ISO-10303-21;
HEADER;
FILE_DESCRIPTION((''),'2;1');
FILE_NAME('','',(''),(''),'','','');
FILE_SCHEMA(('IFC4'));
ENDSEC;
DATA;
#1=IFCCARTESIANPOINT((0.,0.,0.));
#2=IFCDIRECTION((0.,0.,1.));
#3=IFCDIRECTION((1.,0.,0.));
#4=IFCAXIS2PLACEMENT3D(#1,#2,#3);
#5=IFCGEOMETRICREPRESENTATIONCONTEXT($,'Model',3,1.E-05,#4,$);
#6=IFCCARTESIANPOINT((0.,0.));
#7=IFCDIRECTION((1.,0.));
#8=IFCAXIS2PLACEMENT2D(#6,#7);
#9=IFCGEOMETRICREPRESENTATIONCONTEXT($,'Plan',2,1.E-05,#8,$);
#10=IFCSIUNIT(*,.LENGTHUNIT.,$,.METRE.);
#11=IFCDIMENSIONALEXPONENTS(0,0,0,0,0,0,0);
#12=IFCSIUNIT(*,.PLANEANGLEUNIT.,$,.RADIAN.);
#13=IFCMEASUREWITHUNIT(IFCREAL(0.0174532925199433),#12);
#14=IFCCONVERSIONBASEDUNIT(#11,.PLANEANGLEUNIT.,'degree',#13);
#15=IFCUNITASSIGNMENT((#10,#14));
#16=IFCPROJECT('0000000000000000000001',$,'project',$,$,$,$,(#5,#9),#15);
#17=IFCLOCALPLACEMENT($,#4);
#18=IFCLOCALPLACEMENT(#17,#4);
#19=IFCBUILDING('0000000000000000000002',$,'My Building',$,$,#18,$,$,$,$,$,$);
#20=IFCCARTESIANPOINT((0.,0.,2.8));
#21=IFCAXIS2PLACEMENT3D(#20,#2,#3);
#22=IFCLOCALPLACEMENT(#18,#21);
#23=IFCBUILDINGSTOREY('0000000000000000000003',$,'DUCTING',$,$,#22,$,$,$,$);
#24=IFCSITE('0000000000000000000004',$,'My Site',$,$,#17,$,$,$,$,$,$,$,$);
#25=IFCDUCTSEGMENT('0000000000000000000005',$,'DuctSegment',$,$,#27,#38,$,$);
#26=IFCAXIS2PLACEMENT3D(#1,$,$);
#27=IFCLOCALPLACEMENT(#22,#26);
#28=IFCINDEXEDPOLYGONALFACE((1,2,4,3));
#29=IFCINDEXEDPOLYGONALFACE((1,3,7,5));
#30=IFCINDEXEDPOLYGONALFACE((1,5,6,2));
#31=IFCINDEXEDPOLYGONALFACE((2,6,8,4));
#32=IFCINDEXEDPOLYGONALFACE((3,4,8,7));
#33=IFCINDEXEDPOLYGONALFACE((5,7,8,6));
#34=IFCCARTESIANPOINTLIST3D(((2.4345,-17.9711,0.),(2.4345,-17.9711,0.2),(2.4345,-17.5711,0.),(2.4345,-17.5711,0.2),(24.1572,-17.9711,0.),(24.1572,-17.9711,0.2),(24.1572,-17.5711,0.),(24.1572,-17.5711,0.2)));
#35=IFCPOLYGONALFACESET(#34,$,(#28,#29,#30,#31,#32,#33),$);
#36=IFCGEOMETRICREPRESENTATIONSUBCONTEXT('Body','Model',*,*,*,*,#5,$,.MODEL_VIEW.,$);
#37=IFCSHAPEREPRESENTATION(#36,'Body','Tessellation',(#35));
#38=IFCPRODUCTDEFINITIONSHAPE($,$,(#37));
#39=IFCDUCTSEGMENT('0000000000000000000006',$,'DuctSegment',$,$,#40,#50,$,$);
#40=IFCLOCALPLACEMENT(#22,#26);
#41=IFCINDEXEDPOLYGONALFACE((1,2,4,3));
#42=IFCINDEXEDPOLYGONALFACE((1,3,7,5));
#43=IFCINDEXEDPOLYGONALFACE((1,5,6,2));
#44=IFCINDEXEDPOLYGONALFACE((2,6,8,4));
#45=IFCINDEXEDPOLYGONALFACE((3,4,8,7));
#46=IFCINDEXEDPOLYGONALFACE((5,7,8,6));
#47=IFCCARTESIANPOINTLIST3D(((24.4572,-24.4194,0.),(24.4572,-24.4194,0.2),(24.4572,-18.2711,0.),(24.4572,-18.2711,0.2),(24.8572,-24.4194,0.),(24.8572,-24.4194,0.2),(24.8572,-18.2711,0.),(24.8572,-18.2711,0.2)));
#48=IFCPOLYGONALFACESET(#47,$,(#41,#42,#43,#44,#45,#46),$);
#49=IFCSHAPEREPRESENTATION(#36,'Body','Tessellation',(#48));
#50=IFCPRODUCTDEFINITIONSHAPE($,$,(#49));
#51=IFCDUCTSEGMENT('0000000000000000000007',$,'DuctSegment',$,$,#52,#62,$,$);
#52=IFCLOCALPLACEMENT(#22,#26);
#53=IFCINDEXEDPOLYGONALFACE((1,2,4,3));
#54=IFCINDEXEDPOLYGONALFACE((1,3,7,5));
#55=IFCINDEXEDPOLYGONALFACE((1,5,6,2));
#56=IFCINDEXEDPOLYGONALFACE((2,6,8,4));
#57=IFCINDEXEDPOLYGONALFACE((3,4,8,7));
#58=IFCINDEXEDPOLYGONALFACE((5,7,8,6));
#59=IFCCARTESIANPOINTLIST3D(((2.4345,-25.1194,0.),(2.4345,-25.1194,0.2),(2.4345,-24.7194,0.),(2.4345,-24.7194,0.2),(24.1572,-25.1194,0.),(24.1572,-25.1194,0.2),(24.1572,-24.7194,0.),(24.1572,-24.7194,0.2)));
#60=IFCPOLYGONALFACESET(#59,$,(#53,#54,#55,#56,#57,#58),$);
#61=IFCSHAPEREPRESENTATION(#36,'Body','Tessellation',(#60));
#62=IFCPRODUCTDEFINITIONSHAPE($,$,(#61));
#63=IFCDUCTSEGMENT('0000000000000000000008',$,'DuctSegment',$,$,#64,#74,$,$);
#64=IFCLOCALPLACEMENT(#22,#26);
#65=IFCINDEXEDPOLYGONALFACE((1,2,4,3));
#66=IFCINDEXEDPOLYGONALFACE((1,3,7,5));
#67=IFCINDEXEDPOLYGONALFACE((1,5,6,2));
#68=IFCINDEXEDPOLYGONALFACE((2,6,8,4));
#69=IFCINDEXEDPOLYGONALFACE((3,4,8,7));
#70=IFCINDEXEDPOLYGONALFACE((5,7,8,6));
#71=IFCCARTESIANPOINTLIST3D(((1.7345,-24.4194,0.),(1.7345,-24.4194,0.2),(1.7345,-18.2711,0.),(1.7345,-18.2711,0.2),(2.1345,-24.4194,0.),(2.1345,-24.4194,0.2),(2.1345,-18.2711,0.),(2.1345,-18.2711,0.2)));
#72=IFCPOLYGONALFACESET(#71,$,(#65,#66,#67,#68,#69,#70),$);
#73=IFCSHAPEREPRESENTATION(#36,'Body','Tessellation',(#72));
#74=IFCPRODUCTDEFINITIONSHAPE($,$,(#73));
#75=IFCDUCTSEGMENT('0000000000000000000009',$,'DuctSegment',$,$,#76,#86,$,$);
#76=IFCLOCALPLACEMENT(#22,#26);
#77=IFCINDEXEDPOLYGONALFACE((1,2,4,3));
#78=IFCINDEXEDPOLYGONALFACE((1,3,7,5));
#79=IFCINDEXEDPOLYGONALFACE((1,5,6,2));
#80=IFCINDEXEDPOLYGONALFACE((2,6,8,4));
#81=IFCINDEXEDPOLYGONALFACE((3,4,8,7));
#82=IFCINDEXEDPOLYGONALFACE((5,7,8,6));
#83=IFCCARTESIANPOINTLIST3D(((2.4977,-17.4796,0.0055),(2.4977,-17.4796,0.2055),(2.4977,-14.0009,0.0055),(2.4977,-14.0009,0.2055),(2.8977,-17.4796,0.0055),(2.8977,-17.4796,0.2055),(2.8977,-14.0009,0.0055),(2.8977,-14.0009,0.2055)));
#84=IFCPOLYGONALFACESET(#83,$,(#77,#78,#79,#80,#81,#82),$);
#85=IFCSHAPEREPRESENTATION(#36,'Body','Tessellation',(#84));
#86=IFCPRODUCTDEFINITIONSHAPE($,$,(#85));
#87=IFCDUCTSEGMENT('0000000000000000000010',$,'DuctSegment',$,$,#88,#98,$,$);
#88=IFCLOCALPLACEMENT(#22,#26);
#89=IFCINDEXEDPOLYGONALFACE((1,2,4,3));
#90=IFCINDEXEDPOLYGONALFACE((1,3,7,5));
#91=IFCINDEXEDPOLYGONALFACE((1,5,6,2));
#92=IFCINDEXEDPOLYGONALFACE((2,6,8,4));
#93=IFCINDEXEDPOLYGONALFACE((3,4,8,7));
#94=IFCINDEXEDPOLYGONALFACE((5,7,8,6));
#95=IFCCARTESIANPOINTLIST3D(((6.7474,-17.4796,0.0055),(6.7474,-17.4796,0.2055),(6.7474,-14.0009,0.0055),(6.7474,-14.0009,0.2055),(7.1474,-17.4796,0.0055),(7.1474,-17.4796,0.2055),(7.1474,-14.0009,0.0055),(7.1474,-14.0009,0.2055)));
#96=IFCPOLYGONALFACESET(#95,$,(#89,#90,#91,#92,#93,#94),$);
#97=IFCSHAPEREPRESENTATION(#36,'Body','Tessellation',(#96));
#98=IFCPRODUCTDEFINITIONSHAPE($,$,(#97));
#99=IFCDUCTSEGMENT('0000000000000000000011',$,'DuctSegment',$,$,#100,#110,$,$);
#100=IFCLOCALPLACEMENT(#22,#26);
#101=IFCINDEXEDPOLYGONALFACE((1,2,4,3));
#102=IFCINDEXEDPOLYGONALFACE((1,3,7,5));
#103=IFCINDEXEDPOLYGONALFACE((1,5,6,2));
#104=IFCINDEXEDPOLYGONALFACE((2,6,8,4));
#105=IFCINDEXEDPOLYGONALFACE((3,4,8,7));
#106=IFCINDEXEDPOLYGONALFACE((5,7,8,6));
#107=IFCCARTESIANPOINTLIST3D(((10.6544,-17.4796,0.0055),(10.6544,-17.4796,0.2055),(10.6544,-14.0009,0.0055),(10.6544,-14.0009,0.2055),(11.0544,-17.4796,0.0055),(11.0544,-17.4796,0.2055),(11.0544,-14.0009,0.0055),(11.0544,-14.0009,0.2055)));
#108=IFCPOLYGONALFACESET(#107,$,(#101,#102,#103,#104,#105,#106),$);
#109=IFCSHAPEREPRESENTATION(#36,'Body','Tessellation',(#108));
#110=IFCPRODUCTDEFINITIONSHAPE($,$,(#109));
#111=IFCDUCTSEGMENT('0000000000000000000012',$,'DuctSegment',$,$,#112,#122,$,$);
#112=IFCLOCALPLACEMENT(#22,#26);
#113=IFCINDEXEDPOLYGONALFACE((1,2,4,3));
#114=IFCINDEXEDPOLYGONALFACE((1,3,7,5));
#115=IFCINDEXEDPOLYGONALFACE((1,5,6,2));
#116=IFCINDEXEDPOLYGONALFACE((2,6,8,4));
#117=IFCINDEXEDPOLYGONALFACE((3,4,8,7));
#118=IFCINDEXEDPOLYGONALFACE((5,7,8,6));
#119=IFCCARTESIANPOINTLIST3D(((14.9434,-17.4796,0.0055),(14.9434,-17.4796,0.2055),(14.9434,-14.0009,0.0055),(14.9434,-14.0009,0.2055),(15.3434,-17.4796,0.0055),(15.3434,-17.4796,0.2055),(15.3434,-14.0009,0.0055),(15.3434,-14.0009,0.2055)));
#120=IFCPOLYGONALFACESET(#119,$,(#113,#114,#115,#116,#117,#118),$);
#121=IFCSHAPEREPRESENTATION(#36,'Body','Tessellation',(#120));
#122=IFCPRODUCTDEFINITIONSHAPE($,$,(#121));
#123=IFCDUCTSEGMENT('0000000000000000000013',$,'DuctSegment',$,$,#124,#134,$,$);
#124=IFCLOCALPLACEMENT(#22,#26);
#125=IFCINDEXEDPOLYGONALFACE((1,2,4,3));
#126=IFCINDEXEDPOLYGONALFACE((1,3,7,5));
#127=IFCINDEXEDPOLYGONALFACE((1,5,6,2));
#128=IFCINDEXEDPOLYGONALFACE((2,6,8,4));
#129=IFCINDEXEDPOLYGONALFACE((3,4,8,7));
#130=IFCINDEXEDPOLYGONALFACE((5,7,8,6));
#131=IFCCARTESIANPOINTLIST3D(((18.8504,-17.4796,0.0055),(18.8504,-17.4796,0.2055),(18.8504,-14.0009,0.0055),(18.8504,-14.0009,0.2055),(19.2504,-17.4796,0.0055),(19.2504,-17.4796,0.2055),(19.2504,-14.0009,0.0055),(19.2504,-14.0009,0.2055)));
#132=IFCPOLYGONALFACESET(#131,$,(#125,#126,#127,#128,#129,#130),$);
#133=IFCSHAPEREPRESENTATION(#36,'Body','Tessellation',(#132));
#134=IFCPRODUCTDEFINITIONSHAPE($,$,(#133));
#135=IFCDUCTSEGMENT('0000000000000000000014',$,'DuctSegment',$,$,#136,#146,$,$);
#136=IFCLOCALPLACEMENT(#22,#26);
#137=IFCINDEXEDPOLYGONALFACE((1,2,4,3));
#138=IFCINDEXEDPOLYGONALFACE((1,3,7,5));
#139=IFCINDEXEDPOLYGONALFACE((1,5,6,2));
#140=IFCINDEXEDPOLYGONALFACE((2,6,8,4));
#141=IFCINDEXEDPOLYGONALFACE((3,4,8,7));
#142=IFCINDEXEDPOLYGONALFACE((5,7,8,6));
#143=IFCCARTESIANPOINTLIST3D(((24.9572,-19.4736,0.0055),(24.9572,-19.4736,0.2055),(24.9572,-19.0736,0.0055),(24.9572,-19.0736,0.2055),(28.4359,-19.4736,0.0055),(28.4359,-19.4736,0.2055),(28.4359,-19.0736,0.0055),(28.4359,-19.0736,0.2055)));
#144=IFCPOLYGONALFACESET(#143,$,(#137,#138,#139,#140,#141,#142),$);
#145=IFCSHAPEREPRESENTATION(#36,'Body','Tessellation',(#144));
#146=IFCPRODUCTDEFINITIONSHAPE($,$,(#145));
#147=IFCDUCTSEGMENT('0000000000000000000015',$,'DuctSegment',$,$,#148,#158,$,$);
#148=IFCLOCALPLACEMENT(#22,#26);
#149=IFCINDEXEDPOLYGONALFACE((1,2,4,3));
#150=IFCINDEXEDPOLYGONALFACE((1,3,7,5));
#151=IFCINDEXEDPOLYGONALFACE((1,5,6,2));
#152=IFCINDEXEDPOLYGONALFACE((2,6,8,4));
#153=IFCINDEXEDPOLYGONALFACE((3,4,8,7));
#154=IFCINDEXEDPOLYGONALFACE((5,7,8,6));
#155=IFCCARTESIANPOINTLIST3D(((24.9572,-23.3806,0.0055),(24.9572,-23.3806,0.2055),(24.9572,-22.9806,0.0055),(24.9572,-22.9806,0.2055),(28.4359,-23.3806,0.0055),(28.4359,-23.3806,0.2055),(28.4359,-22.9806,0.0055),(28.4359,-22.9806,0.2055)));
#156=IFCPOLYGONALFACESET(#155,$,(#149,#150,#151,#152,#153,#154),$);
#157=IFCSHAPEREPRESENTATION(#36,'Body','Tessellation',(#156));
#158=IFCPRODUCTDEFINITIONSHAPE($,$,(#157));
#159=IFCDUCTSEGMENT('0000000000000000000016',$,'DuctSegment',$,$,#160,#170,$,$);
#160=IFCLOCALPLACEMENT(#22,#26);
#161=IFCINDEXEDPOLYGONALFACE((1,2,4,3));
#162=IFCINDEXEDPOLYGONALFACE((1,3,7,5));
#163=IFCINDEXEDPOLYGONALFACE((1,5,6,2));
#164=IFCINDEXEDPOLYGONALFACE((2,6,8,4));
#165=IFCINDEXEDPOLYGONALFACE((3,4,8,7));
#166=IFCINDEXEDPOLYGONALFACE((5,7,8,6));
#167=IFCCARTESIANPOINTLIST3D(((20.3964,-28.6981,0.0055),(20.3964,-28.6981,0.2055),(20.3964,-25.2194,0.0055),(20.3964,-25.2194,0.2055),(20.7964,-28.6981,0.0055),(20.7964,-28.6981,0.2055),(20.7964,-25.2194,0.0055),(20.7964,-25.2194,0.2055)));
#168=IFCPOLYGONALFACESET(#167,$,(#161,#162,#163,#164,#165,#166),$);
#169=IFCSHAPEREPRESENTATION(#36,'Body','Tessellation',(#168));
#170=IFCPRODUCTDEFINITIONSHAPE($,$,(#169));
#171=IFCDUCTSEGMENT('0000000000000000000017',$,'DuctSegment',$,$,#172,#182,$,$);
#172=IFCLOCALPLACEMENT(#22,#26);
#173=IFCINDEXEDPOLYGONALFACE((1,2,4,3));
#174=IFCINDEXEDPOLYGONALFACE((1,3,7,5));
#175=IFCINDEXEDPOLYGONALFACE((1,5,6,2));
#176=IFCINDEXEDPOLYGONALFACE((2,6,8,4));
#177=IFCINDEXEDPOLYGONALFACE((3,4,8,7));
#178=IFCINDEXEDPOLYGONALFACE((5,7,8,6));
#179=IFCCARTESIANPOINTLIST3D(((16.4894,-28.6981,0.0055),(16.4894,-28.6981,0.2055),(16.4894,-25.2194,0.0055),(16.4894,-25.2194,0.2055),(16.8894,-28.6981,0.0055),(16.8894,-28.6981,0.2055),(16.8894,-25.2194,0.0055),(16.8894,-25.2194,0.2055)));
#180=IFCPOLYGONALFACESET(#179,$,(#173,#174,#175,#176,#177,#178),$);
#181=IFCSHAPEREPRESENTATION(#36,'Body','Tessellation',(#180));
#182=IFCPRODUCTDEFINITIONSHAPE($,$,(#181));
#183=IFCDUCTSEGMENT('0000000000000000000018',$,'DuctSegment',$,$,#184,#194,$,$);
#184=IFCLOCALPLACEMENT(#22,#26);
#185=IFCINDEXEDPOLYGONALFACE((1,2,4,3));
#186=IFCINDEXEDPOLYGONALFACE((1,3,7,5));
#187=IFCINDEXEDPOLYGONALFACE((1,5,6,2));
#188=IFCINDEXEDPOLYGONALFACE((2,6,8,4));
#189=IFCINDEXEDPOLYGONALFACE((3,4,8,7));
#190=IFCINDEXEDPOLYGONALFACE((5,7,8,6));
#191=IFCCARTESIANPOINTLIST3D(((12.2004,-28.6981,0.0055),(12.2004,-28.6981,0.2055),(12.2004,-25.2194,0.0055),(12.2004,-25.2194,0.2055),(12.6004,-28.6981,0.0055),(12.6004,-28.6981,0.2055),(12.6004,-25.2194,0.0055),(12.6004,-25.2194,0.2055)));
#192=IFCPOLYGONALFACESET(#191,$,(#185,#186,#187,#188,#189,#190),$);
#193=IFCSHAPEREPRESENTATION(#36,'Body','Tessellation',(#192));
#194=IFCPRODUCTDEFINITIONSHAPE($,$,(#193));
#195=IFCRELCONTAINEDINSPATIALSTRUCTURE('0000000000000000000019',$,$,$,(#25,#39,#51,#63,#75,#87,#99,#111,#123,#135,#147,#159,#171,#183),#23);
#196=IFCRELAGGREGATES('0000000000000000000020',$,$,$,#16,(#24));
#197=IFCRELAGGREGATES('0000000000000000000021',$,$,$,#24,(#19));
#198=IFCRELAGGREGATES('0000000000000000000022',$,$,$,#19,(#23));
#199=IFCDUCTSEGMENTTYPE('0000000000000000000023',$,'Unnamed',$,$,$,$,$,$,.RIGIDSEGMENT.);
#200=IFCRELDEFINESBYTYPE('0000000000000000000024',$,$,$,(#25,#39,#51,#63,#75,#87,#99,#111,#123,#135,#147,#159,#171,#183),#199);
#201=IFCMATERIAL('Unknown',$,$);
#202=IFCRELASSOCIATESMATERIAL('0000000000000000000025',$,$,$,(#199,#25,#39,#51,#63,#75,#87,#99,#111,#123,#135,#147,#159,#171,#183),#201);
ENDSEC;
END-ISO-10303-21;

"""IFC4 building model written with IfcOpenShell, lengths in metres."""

from ifc_helpers import new_model, entity, si_unit, converted_unit, frame, origin_with_axes, origin_2d_with_axis, place, context, subcontext, project, spatial, rectangle, extrude, material, material_profile, profile_set, profile_usage, type_object, element, save


model = new_model("IFC4")

# Units and contexts
model_context = context("Model", 3, precision=1e-05, world=origin_with_axes())
plan_context = context("Plan", 2, precision=1e-05, world=origin_2d_with_axis())
body_context = subcontext(model_context, "Body", "Model", "MODEL_VIEW")
ifc_project = project(units=[si_unit("LENGTHUNIT", "METRE"), converted_unit("PLANEANGLEUNIT", "degree", entity("IfcReal", 0.0174532925199433), si_unit("PLANEANGLEUNIT", "RADIAN"), dimensions=[0, 0, 0, 0, 0, 0, 0])], contexts=[model_context, plan_context])

# Site, building, storey
site_placement = place(None, origin_with_axes())
site = spatial("IfcSite", under=ifc_project, at=site_placement, Name="My Site")
building_placement = place(site_placement, origin_with_axes())
building = spatial("IfcBuilding", under=site, at=building_placement, Name="My Building")
storey_placement = place(building_placement, frame((0.0, 0.0, 2.8), z_axis=(0.0, 0.0, 1.0), x_axis=(1.0, 0.0, 0.0)))
storey = spatial("IfcBuildingStorey", under=building, at=storey_placement, Name="DUCTING")

# Duct segments
ifc_material = material(Name="Unknown")
ifc_material_profile = material_profile(ifc_material, rectangle(XDim=0.4, YDim=0.2))
ifc_profile_set = profile_set([ifc_material_profile])
ifc_profile_usage_1 = profile_usage(ifc_profile_set, cardinal=5)
duct_segment_type = type_object("IfcDuctSegmentType", Name="Unnamed", PredefinedType="RIGIDSEGMENT", material=ifc_profile_set)
duct_segment_1_placement = place(storey_placement, frame((24.1572, -17.7711, 0.1), z_axis=(-1.0, 0.0, 0.0), x_axis=(0.0, -1.0, 0.0)))
element("IfcDuctSegment", 1, at=duct_segment_1_placement, inside=storey, type_object=duct_segment_type, material=ifc_profile_usage_1, Name="DuctSegment", context=body_context, shape_type="SweptSolid", body=[
    extrude(rectangle(XDim=0.4, YDim=0.2), origin_with_axes(), (0.0, 0.0, 1.0), 21.7227),
])
ifc_profile_usage_2 = profile_usage(ifc_profile_set, cardinal=5)
duct_segment_2_placement = place(storey_placement, frame((24.6572, -18.2711, 0.1), z_axis=(0.0, -1.0, 0.0), x_axis=(1.0, 0.0, 0.0)))
element("IfcDuctSegment", 2, at=duct_segment_2_placement, inside=storey, type_object=duct_segment_type, material=ifc_profile_usage_2, Name="DuctSegment", context=body_context, shape_type="SweptSolid", body=[
    extrude(rectangle(XDim=0.4, YDim=0.2), origin_with_axes(), (0.0, 0.0, 1.0), 6.1483),
])
ifc_profile_usage_3 = profile_usage(ifc_profile_set, cardinal=5)
duct_segment_3_placement = place(storey_placement, frame((24.1572, -24.9194, 0.1), z_axis=(-1.0, 0.0, 0.0), x_axis=(0.0, -1.0, 0.0)))
element("IfcDuctSegment", 3, at=duct_segment_3_placement, inside=storey, type_object=duct_segment_type, material=ifc_profile_usage_3, Name="DuctSegment", context=body_context, shape_type="SweptSolid", body=[
    extrude(rectangle(XDim=0.4, YDim=0.2), origin_with_axes(), (0.0, 0.0, 1.0), 21.7227),
])
ifc_profile_usage_4 = profile_usage(ifc_profile_set, cardinal=5)
duct_segment_4_placement = place(storey_placement, frame((1.9345, -18.2711, 0.1), z_axis=(0.0, -1.0, 0.0), x_axis=(1.0, 0.0, 0.0)))
element("IfcDuctSegment", 4, at=duct_segment_4_placement, inside=storey, type_object=duct_segment_type, material=ifc_profile_usage_4, Name="DuctSegment", context=body_context, shape_type="SweptSolid", body=[
    extrude(rectangle(XDim=0.4, YDim=0.2), origin_with_axes(), (0.0, 0.0, 1.0), 6.1483),
])
ifc_profile_usage_5 = profile_usage(ifc_profile_set, cardinal=5)
duct_segment_5_placement = place(storey_placement, frame((2.6977, -17.4796, 0.1055), z_axis=(0.0, 1.0, 0.0), x_axis=(-1.0, 0.0, 0.0)))
element("IfcDuctSegment", 5, at=duct_segment_5_placement, inside=storey, type_object=duct_segment_type, material=ifc_profile_usage_5, Name="DuctSegment", context=body_context, shape_type="SweptSolid", body=[
    extrude(rectangle(XDim=0.4, YDim=0.2), origin_with_axes(), (0.0, 0.0, 1.0), 3.4787),
])
ifc_profile_usage_6 = profile_usage(ifc_profile_set, cardinal=5)
duct_segment_6_placement = place(storey_placement, frame((6.9474, -17.4796, 0.1055), z_axis=(0.0, 1.0, 0.0), x_axis=(-1.0, 0.0, 0.0)))
element("IfcDuctSegment", 6, at=duct_segment_6_placement, inside=storey, type_object=duct_segment_type, material=ifc_profile_usage_6, Name="DuctSegment", context=body_context, shape_type="SweptSolid", body=[
    extrude(rectangle(XDim=0.4, YDim=0.2), origin_with_axes(), (0.0, 0.0, 1.0), 3.4787),
])
ifc_profile_usage_7 = profile_usage(ifc_profile_set, cardinal=5)
duct_segment_7_placement = place(storey_placement, frame((10.8544, -17.4796, 0.1055), z_axis=(0.0, 1.0, 0.0), x_axis=(-1.0, 0.0, 0.0)))
element("IfcDuctSegment", 7, at=duct_segment_7_placement, inside=storey, type_object=duct_segment_type, material=ifc_profile_usage_7, Name="DuctSegment", context=body_context, shape_type="SweptSolid", body=[
    extrude(rectangle(XDim=0.4, YDim=0.2), origin_with_axes(), (0.0, 0.0, 1.0), 3.4787),
])
ifc_profile_usage_8 = profile_usage(ifc_profile_set, cardinal=5)
duct_segment_8_placement = place(storey_placement, frame((15.1434, -17.4796, 0.1055), z_axis=(0.0, 1.0, 0.0), x_axis=(-1.0, 0.0, 0.0)))
element("IfcDuctSegment", 8, at=duct_segment_8_placement, inside=storey, type_object=duct_segment_type, material=ifc_profile_usage_8, Name="DuctSegment", context=body_context, shape_type="SweptSolid", body=[
    extrude(rectangle(XDim=0.4, YDim=0.2), origin_with_axes(), (0.0, 0.0, 1.0), 3.4787),
])
ifc_profile_usage_9 = profile_usage(ifc_profile_set, cardinal=5)
duct_segment_9_placement = place(storey_placement, frame((19.0504, -17.4796, 0.1055), z_axis=(0.0, 1.0, 0.0), x_axis=(-1.0, 0.0, 0.0)))
element("IfcDuctSegment", 9, at=duct_segment_9_placement, inside=storey, type_object=duct_segment_type, material=ifc_profile_usage_9, Name="DuctSegment", context=body_context, shape_type="SweptSolid", body=[
    extrude(rectangle(XDim=0.4, YDim=0.2), origin_with_axes(), (0.0, 0.0, 1.0), 3.4787),
])
ifc_profile_usage_10 = profile_usage(ifc_profile_set, cardinal=5)
duct_segment_10_placement = place(storey_placement, frame((24.9572, -19.2736, 0.1055), z_axis=(1.0, 0.0, 0.0), x_axis=(0.0, 1.0, 0.0)))
element("IfcDuctSegment", 10, at=duct_segment_10_placement, inside=storey, type_object=duct_segment_type, material=ifc_profile_usage_10, Name="DuctSegment", context=body_context, shape_type="SweptSolid", body=[
    extrude(rectangle(XDim=0.4, YDim=0.2), origin_with_axes(), (0.0, 0.0, 1.0), 3.4787),
])
ifc_profile_usage_11 = profile_usage(ifc_profile_set, cardinal=5)
duct_segment_11_placement = place(storey_placement, frame((24.9572, -23.1806, 0.1055), z_axis=(1.0, 0.0, 0.0), x_axis=(0.0, 1.0, 0.0)))
element("IfcDuctSegment", 11, at=duct_segment_11_placement, inside=storey, type_object=duct_segment_type, material=ifc_profile_usage_11, Name="DuctSegment", context=body_context, shape_type="SweptSolid", body=[
    extrude(rectangle(XDim=0.4, YDim=0.2), origin_with_axes(), (0.0, 0.0, 1.0), 3.4787),
])
ifc_profile_usage_12 = profile_usage(ifc_profile_set, cardinal=5)
duct_segment_12_placement = place(storey_placement, frame((20.5964, -25.2194, 0.1055), z_axis=(0.0, -1.0, 0.0), x_axis=(1.0, 0.0, 0.0)))
element("IfcDuctSegment", 12, at=duct_segment_12_placement, inside=storey, type_object=duct_segment_type, material=ifc_profile_usage_12, Name="DuctSegment", context=body_context, shape_type="SweptSolid", body=[
    extrude(rectangle(XDim=0.4, YDim=0.2), origin_with_axes(), (0.0, 0.0, 1.0), 3.4787),
])
ifc_profile_usage_13 = profile_usage(ifc_profile_set, cardinal=5)
duct_segment_13_placement = place(storey_placement, frame((16.6894, -25.2194, 0.1055), z_axis=(0.0, -1.0, 0.0), x_axis=(1.0, 0.0, 0.0)))
element("IfcDuctSegment", 13, at=duct_segment_13_placement, inside=storey, type_object=duct_segment_type, material=ifc_profile_usage_13, Name="DuctSegment", context=body_context, shape_type="SweptSolid", body=[
    extrude(rectangle(XDim=0.4, YDim=0.2), origin_with_axes(), (0.0, 0.0, 1.0), 3.4787),
])
ifc_profile_usage_14 = profile_usage(ifc_profile_set, cardinal=5)
duct_segment_14_placement = place(storey_placement, frame((12.4004, -25.2194, 0.1055), z_axis=(0.0, -1.0, 0.0), x_axis=(1.0, 0.0, 0.0)))
element("IfcDuctSegment", 14, at=duct_segment_14_placement, inside=storey, type_object=duct_segment_type, material=ifc_profile_usage_14, Name="DuctSegment", context=body_context, shape_type="SweptSolid", body=[
    extrude(rectangle(XDim=0.4, YDim=0.2), origin_with_axes(), (0.0, 0.0, 1.0), 3.4787),
])

save(model, "model.ifc")
